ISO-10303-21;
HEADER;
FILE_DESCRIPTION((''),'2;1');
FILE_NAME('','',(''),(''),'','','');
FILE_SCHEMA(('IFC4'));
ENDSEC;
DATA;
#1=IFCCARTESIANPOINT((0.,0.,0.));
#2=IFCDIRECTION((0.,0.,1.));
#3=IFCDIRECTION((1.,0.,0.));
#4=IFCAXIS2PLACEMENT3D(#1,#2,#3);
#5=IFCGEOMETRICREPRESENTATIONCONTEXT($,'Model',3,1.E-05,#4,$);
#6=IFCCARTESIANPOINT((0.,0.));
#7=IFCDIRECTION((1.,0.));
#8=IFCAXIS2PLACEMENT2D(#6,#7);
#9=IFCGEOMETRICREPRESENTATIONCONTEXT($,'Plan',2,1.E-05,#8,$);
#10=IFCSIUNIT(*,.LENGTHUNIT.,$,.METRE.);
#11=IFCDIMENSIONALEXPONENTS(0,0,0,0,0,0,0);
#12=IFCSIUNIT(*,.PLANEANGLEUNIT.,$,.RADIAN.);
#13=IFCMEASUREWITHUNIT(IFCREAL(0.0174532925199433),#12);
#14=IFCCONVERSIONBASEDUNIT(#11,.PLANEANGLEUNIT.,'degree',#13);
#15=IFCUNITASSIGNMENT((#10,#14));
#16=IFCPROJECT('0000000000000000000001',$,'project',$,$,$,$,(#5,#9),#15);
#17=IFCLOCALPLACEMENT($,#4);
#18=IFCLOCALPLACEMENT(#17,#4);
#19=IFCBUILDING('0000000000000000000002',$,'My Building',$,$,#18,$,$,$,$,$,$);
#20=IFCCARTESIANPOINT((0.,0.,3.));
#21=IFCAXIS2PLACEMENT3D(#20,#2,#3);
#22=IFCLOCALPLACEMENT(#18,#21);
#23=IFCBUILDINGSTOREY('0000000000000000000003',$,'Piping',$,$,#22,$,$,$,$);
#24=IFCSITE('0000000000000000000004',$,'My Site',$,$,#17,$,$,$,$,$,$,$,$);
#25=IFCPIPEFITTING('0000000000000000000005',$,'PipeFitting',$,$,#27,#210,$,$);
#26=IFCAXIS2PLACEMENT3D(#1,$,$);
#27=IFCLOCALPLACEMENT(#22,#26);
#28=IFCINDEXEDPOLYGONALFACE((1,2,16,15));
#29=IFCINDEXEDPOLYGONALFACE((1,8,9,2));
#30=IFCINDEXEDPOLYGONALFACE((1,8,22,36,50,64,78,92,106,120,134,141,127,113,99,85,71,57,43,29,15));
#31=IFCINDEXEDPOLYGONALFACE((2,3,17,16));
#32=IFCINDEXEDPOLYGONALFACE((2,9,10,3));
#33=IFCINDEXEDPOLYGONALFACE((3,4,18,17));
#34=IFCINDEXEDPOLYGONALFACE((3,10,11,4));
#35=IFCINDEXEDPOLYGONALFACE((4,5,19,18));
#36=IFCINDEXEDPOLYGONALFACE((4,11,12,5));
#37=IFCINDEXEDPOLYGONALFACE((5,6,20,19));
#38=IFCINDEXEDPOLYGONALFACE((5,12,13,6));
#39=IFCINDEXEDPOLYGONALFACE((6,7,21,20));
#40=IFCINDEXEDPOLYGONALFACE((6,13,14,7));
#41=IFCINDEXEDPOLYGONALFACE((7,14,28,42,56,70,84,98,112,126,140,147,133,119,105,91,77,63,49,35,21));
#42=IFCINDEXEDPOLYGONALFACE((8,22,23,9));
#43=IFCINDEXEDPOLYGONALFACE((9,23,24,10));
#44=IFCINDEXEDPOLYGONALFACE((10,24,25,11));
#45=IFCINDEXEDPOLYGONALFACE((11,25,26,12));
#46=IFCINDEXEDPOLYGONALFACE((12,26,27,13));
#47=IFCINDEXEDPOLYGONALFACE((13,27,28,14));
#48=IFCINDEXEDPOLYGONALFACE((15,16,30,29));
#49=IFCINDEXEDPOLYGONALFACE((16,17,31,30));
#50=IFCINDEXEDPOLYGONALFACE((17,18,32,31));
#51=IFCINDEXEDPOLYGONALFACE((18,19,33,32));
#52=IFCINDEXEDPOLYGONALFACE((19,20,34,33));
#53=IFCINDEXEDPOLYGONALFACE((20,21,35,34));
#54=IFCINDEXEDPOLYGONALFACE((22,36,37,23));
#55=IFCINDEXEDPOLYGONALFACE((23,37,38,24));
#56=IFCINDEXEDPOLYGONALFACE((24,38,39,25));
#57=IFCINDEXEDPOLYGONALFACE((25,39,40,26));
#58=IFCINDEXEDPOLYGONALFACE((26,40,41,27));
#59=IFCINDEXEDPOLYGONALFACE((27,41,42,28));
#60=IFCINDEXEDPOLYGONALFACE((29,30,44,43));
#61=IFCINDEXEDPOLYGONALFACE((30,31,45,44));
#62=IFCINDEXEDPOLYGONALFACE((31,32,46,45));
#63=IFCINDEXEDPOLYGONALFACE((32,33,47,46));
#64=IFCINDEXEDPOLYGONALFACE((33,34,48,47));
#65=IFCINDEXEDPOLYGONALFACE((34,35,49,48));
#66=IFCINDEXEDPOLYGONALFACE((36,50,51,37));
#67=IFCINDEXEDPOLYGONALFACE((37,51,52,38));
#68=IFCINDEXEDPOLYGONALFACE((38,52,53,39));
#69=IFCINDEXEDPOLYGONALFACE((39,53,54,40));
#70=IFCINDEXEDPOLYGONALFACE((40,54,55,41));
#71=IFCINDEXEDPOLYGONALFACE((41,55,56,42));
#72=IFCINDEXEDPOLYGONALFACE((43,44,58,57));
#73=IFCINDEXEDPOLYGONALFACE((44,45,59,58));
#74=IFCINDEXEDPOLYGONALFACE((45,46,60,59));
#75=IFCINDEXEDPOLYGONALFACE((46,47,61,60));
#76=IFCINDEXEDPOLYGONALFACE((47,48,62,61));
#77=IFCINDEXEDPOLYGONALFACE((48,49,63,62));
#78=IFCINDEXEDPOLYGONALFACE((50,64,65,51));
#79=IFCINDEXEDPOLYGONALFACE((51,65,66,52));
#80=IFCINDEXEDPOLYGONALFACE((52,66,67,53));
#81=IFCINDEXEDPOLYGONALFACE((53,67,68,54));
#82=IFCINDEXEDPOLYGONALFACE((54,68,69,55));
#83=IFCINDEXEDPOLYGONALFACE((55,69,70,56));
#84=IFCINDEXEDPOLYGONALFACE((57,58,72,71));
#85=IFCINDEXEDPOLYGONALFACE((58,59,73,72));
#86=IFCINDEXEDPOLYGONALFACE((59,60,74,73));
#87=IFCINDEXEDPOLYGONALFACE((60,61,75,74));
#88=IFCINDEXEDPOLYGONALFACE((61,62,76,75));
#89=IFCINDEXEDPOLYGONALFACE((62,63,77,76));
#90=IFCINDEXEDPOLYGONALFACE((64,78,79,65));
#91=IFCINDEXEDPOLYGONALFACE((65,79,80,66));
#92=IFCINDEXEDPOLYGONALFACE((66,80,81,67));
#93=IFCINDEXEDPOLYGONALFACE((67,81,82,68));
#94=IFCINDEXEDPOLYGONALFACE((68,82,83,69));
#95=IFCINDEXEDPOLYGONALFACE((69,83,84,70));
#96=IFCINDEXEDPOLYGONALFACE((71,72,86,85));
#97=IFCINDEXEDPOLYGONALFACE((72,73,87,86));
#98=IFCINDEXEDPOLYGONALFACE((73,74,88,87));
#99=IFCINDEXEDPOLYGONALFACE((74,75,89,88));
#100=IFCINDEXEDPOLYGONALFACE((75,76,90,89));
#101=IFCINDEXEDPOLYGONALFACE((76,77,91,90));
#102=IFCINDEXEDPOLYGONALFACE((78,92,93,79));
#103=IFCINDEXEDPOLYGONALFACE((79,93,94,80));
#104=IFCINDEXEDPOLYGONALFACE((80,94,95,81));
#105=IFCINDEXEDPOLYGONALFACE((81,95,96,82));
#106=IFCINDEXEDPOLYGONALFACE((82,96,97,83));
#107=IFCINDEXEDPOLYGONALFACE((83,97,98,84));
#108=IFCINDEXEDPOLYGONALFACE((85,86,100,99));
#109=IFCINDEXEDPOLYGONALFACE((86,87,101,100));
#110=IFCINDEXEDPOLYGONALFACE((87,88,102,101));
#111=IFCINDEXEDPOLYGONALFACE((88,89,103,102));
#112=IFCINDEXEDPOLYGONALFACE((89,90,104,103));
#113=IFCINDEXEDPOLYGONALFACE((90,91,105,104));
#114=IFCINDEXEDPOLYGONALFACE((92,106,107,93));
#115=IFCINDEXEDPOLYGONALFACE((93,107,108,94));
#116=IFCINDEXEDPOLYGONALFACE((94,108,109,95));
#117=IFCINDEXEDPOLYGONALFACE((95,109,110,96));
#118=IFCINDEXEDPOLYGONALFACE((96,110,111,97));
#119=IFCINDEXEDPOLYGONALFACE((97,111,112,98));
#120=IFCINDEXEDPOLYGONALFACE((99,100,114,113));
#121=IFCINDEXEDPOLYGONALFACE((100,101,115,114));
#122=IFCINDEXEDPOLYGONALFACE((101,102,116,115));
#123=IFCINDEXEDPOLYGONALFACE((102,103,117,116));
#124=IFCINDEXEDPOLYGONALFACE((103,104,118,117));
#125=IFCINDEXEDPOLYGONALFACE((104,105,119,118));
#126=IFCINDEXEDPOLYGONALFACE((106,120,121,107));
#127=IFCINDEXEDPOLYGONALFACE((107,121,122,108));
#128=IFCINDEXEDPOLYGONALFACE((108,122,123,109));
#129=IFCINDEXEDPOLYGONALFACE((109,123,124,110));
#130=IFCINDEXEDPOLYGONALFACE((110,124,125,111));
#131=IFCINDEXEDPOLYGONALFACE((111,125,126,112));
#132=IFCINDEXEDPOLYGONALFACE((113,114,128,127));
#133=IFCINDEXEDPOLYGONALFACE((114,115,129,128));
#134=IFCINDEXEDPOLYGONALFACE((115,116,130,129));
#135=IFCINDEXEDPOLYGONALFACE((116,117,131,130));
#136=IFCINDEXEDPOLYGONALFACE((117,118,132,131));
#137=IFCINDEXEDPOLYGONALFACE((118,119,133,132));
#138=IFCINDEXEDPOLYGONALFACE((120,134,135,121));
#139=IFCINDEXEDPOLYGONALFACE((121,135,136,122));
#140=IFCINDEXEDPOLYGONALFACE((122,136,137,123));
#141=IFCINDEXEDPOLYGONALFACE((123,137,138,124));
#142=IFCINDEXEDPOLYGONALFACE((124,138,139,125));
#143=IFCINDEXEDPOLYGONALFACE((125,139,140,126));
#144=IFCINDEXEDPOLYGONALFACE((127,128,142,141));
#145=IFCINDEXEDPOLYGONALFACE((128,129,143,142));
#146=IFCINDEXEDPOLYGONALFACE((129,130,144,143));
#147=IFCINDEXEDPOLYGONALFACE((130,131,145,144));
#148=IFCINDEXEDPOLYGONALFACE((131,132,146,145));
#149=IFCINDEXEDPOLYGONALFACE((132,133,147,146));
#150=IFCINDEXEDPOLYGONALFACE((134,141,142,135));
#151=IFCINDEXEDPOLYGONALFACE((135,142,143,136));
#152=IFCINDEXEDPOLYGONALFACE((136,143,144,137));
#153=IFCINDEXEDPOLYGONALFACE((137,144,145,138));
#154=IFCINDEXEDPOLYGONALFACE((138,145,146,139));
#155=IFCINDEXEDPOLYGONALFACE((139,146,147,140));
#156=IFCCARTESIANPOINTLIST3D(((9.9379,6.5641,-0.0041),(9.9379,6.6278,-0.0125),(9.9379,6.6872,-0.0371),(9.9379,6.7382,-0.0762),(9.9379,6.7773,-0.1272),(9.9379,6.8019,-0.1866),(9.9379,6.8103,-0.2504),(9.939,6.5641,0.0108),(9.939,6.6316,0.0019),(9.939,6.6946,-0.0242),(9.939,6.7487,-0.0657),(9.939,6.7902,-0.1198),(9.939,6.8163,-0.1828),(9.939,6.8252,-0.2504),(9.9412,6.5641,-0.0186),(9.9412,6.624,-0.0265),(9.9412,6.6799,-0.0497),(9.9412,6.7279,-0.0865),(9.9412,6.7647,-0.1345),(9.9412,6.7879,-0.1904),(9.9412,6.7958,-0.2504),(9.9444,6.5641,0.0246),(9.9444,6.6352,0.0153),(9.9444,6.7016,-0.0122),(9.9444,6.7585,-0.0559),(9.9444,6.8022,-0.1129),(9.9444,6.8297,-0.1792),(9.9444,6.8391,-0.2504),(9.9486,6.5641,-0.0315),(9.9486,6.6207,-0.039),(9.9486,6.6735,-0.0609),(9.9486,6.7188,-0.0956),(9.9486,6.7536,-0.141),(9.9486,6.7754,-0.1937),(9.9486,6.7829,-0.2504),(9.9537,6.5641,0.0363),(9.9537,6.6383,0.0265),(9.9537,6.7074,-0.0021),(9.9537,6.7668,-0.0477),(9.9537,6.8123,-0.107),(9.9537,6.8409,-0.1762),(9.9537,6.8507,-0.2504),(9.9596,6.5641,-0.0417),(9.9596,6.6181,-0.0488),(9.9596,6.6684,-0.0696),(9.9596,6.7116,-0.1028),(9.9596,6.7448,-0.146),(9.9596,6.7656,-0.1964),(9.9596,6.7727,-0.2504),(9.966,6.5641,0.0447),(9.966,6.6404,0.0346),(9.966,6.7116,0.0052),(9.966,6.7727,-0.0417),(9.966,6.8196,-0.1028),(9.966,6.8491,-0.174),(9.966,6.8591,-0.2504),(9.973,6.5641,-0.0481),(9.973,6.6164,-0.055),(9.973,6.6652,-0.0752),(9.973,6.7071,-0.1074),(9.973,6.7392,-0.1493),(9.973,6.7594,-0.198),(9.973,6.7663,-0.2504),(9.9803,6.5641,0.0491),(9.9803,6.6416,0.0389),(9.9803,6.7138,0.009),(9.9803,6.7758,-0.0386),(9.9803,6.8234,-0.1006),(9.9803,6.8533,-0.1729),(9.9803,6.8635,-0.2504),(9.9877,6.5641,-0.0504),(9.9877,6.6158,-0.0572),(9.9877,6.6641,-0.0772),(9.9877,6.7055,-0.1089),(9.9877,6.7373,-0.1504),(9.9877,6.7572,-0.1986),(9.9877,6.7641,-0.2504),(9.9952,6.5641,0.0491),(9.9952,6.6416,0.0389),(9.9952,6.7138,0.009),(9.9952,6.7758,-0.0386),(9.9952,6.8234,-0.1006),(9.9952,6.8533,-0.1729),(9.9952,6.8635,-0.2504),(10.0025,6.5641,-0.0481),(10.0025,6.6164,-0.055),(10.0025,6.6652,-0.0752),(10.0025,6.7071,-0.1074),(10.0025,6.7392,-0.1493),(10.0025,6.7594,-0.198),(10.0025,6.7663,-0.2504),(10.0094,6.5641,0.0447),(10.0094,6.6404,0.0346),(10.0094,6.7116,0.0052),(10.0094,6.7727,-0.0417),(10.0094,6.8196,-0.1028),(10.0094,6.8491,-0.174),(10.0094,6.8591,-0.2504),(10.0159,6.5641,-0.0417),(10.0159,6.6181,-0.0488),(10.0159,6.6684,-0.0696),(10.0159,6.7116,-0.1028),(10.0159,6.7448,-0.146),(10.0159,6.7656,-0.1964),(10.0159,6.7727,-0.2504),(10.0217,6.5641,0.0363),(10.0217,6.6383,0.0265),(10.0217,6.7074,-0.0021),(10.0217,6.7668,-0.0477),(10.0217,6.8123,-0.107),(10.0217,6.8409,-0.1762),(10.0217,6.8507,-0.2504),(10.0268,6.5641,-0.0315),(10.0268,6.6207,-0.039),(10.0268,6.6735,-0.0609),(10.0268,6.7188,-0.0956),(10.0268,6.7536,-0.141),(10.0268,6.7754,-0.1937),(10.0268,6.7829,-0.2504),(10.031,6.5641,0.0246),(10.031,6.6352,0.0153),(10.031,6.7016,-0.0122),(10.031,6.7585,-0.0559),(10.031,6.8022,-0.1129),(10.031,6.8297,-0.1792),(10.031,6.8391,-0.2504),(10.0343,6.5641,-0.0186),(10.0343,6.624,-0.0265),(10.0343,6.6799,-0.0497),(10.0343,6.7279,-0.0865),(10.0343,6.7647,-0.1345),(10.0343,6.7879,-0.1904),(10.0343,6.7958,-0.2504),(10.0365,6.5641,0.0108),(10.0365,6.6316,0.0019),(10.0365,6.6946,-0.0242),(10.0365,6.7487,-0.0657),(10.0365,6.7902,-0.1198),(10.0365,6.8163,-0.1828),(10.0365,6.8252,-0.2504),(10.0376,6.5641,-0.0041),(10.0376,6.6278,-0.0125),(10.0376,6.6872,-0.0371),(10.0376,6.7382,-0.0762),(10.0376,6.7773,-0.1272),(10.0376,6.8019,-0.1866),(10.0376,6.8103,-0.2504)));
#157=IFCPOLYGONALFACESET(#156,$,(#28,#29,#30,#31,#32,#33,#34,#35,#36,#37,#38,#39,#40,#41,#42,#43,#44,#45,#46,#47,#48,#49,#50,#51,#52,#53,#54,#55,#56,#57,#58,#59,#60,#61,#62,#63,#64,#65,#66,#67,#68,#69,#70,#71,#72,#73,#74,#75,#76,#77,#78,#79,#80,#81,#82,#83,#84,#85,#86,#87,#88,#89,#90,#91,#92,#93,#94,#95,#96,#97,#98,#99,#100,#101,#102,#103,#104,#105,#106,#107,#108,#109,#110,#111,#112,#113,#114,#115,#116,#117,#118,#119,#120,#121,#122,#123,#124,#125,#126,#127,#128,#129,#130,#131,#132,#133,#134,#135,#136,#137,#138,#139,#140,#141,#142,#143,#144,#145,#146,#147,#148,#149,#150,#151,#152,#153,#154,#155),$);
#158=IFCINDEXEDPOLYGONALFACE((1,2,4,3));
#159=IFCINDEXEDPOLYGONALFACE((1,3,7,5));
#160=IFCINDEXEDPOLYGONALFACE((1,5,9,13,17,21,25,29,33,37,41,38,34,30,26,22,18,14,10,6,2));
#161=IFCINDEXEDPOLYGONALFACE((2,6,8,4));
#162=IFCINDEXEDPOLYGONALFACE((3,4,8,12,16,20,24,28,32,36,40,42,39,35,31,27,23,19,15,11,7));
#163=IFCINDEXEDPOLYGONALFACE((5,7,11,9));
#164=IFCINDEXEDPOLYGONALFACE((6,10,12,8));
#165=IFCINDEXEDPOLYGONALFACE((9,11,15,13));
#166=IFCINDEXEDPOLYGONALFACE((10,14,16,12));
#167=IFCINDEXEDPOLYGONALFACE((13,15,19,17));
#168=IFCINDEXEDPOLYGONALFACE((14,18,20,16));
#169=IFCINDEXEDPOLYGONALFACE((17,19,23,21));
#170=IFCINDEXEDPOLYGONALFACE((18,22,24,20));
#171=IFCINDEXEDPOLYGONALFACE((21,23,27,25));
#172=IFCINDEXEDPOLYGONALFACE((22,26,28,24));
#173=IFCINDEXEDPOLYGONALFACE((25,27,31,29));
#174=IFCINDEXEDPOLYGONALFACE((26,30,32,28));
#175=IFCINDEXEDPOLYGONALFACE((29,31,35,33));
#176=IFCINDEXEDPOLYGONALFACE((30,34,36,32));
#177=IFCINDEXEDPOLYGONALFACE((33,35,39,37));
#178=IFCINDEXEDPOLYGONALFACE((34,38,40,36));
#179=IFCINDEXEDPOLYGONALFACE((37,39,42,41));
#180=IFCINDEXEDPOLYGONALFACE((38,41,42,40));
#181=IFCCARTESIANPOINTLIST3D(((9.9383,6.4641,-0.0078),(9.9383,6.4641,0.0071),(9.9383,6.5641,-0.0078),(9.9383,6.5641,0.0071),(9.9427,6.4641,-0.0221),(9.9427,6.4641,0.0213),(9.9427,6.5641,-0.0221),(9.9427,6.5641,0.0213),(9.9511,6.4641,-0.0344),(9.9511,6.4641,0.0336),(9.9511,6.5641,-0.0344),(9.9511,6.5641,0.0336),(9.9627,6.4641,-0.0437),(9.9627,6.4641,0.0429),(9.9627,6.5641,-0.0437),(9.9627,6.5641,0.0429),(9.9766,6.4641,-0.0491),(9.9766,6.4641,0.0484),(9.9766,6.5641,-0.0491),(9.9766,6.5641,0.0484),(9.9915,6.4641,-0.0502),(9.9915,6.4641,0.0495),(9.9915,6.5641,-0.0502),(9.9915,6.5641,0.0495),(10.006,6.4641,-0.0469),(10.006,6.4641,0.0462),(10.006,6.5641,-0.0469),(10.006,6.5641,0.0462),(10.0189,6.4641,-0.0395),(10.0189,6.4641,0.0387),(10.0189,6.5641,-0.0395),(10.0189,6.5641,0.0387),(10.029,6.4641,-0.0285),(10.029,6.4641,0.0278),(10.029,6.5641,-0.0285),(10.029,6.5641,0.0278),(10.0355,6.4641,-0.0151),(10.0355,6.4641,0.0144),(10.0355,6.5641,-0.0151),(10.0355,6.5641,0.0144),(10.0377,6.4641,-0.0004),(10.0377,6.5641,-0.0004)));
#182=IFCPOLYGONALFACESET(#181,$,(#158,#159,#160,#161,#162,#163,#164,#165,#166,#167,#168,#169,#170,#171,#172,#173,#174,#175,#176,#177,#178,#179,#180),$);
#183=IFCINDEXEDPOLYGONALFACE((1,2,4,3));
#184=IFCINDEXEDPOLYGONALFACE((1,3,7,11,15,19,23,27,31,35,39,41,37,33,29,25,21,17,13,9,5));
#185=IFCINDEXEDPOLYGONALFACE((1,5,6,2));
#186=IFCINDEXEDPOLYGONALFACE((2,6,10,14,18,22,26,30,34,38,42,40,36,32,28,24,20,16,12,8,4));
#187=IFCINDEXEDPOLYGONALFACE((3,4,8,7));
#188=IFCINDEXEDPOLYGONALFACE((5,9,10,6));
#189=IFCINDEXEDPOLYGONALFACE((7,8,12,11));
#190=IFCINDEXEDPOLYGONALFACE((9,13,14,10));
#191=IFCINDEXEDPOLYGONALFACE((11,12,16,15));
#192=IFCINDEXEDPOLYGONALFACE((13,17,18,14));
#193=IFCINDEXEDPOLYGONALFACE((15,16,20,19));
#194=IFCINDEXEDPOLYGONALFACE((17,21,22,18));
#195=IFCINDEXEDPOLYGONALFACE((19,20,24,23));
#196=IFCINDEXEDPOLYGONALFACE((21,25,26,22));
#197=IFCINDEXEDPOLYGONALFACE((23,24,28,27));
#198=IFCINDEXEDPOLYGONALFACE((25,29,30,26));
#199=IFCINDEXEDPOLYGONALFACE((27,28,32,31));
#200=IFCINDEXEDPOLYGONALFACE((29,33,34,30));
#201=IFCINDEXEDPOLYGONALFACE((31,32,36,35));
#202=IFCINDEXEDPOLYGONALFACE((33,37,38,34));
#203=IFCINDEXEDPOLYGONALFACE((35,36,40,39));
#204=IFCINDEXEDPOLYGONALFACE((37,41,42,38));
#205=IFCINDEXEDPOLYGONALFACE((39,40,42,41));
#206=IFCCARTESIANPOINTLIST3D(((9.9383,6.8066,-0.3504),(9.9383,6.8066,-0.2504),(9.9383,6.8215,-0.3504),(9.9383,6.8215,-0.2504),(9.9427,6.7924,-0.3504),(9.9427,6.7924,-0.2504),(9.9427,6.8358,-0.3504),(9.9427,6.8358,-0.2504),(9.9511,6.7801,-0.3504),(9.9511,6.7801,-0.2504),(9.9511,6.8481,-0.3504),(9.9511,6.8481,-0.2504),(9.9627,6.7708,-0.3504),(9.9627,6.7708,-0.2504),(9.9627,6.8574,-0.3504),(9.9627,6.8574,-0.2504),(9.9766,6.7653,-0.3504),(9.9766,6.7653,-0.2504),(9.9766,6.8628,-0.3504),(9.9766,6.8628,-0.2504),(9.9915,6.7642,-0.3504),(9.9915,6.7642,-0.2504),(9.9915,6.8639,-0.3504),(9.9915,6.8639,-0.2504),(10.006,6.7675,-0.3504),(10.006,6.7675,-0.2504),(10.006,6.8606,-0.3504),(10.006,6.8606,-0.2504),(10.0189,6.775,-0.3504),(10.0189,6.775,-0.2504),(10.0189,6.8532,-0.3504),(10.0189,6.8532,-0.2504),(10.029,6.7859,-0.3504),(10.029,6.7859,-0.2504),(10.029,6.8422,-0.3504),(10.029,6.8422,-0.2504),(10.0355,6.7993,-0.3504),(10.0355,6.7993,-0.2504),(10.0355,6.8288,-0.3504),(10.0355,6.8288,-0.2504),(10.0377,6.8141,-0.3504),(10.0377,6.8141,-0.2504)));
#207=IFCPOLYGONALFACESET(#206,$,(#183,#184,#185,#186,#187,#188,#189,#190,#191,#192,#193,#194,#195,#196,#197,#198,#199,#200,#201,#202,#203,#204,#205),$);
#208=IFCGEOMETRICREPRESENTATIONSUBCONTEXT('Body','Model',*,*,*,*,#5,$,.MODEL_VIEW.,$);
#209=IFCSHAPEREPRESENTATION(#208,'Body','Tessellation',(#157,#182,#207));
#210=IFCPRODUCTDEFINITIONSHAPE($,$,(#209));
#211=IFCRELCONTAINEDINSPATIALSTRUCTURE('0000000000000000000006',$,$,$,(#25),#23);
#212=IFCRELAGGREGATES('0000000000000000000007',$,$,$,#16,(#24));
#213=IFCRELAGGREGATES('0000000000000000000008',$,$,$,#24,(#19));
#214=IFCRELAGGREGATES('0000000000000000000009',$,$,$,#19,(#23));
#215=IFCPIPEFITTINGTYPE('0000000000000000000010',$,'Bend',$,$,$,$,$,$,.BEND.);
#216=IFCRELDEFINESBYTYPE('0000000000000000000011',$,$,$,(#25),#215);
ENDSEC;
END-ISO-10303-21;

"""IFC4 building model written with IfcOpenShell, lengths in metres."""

from ifc_helpers import new_model, entity, si_unit, converted_unit, frame, origin_with_axes, origin_2d_with_axis, place, context, subcontext, project, spatial, circle, extrude, source, transform, mapped, type_object, type_shapes, element, save


model = new_model("IFC4")

# Units and contexts
model_context = context("Model", 3, precision=1e-05, world=origin_with_axes())
plan_context = context("Plan", 2, precision=1e-05, world=origin_2d_with_axis())
body_context = subcontext(model_context, "Body", "Model", "MODEL_VIEW")
ifc_project = project(units=[si_unit("LENGTHUNIT", "METRE"), converted_unit("PLANEANGLEUNIT", "degree", entity("IfcReal", 0.0174532925199433), si_unit("PLANEANGLEUNIT", "RADIAN"), dimensions=[0, 0, 0, 0, 0, 0, 0])], contexts=[model_context, plan_context])

# Site, building, storey
site_placement = place(None, origin_with_axes())
site = spatial("IfcSite", under=ifc_project, at=site_placement, Name="My Site")
building_placement = place(site_placement, origin_with_axes())
building = spatial("IfcBuilding", under=site, at=building_placement, Name="My Building")
storey_placement = place(building_placement, frame((0.0, 0.0, 3.0), z_axis=(0.0, 0.0, 1.0), x_axis=(1.0, 0.0, 0.0)))
storey = spatial("IfcBuildingStorey", under=building, at=storey_placement, Name="Piping")

# Shared definitions
pipe_fitting_type = type_object("IfcPipeFittingType", Name="Bend", PredefinedType="BEND")
shared_shape = source(origin_with_axes(), body_context, "Body", "SolidModel", [
    entity("IfcSweptDiskSolid", entity("IfcIndexedPolyCurve", entity("IfcCartesianPointList3D", [[0.0, 0.0, -0.1], [0.0, -0.0732, -0.2768], [0.0, -0.25, -0.35]]), [entity("IfcArcIndex", [1, 2, 3])]), 0.05),
    extrude(circle(Radius=0.05), origin_with_axes(), (0.0, 0.0, -1.0), 0.1),
    extrude(circle(Radius=0.05), frame((0.0, -0.25, -0.35), z_axis=(0.0, -1.0, 0.0), x_axis=(1.0, 0.0, 0.0)), (0.0, 0.0, 1.0), 0.1),
])
type_shapes(pipe_fitting_type, [shared_shape])

# Pipe fitting
for number, where, z_axis, x_axis, name in (
    (1, (9.9877, 6.4641, -0.0004), (0.0, -1.0, 0.0), (1.0, 0.0, 0.0), "PipeFitting"),
):
    element("IfcPipeFitting", number, at=place(storey_placement, frame(where, z_axis=z_axis, x_axis=x_axis)), inside=storey, type_object=pipe_fitting_type, Name=name, context=body_context, shape_type="MappedRepresentation", body=[
        mapped(shared_shape, transform((0.0, 0.0, 0.0), x_axis=(1.0, 0.0, 0.0), y_axis=(0.0, 1.0, 0.0), z_axis=(0.0, 0.0, 1.0), scale=1.0)),
    ])

save(model, "model.ifc")
